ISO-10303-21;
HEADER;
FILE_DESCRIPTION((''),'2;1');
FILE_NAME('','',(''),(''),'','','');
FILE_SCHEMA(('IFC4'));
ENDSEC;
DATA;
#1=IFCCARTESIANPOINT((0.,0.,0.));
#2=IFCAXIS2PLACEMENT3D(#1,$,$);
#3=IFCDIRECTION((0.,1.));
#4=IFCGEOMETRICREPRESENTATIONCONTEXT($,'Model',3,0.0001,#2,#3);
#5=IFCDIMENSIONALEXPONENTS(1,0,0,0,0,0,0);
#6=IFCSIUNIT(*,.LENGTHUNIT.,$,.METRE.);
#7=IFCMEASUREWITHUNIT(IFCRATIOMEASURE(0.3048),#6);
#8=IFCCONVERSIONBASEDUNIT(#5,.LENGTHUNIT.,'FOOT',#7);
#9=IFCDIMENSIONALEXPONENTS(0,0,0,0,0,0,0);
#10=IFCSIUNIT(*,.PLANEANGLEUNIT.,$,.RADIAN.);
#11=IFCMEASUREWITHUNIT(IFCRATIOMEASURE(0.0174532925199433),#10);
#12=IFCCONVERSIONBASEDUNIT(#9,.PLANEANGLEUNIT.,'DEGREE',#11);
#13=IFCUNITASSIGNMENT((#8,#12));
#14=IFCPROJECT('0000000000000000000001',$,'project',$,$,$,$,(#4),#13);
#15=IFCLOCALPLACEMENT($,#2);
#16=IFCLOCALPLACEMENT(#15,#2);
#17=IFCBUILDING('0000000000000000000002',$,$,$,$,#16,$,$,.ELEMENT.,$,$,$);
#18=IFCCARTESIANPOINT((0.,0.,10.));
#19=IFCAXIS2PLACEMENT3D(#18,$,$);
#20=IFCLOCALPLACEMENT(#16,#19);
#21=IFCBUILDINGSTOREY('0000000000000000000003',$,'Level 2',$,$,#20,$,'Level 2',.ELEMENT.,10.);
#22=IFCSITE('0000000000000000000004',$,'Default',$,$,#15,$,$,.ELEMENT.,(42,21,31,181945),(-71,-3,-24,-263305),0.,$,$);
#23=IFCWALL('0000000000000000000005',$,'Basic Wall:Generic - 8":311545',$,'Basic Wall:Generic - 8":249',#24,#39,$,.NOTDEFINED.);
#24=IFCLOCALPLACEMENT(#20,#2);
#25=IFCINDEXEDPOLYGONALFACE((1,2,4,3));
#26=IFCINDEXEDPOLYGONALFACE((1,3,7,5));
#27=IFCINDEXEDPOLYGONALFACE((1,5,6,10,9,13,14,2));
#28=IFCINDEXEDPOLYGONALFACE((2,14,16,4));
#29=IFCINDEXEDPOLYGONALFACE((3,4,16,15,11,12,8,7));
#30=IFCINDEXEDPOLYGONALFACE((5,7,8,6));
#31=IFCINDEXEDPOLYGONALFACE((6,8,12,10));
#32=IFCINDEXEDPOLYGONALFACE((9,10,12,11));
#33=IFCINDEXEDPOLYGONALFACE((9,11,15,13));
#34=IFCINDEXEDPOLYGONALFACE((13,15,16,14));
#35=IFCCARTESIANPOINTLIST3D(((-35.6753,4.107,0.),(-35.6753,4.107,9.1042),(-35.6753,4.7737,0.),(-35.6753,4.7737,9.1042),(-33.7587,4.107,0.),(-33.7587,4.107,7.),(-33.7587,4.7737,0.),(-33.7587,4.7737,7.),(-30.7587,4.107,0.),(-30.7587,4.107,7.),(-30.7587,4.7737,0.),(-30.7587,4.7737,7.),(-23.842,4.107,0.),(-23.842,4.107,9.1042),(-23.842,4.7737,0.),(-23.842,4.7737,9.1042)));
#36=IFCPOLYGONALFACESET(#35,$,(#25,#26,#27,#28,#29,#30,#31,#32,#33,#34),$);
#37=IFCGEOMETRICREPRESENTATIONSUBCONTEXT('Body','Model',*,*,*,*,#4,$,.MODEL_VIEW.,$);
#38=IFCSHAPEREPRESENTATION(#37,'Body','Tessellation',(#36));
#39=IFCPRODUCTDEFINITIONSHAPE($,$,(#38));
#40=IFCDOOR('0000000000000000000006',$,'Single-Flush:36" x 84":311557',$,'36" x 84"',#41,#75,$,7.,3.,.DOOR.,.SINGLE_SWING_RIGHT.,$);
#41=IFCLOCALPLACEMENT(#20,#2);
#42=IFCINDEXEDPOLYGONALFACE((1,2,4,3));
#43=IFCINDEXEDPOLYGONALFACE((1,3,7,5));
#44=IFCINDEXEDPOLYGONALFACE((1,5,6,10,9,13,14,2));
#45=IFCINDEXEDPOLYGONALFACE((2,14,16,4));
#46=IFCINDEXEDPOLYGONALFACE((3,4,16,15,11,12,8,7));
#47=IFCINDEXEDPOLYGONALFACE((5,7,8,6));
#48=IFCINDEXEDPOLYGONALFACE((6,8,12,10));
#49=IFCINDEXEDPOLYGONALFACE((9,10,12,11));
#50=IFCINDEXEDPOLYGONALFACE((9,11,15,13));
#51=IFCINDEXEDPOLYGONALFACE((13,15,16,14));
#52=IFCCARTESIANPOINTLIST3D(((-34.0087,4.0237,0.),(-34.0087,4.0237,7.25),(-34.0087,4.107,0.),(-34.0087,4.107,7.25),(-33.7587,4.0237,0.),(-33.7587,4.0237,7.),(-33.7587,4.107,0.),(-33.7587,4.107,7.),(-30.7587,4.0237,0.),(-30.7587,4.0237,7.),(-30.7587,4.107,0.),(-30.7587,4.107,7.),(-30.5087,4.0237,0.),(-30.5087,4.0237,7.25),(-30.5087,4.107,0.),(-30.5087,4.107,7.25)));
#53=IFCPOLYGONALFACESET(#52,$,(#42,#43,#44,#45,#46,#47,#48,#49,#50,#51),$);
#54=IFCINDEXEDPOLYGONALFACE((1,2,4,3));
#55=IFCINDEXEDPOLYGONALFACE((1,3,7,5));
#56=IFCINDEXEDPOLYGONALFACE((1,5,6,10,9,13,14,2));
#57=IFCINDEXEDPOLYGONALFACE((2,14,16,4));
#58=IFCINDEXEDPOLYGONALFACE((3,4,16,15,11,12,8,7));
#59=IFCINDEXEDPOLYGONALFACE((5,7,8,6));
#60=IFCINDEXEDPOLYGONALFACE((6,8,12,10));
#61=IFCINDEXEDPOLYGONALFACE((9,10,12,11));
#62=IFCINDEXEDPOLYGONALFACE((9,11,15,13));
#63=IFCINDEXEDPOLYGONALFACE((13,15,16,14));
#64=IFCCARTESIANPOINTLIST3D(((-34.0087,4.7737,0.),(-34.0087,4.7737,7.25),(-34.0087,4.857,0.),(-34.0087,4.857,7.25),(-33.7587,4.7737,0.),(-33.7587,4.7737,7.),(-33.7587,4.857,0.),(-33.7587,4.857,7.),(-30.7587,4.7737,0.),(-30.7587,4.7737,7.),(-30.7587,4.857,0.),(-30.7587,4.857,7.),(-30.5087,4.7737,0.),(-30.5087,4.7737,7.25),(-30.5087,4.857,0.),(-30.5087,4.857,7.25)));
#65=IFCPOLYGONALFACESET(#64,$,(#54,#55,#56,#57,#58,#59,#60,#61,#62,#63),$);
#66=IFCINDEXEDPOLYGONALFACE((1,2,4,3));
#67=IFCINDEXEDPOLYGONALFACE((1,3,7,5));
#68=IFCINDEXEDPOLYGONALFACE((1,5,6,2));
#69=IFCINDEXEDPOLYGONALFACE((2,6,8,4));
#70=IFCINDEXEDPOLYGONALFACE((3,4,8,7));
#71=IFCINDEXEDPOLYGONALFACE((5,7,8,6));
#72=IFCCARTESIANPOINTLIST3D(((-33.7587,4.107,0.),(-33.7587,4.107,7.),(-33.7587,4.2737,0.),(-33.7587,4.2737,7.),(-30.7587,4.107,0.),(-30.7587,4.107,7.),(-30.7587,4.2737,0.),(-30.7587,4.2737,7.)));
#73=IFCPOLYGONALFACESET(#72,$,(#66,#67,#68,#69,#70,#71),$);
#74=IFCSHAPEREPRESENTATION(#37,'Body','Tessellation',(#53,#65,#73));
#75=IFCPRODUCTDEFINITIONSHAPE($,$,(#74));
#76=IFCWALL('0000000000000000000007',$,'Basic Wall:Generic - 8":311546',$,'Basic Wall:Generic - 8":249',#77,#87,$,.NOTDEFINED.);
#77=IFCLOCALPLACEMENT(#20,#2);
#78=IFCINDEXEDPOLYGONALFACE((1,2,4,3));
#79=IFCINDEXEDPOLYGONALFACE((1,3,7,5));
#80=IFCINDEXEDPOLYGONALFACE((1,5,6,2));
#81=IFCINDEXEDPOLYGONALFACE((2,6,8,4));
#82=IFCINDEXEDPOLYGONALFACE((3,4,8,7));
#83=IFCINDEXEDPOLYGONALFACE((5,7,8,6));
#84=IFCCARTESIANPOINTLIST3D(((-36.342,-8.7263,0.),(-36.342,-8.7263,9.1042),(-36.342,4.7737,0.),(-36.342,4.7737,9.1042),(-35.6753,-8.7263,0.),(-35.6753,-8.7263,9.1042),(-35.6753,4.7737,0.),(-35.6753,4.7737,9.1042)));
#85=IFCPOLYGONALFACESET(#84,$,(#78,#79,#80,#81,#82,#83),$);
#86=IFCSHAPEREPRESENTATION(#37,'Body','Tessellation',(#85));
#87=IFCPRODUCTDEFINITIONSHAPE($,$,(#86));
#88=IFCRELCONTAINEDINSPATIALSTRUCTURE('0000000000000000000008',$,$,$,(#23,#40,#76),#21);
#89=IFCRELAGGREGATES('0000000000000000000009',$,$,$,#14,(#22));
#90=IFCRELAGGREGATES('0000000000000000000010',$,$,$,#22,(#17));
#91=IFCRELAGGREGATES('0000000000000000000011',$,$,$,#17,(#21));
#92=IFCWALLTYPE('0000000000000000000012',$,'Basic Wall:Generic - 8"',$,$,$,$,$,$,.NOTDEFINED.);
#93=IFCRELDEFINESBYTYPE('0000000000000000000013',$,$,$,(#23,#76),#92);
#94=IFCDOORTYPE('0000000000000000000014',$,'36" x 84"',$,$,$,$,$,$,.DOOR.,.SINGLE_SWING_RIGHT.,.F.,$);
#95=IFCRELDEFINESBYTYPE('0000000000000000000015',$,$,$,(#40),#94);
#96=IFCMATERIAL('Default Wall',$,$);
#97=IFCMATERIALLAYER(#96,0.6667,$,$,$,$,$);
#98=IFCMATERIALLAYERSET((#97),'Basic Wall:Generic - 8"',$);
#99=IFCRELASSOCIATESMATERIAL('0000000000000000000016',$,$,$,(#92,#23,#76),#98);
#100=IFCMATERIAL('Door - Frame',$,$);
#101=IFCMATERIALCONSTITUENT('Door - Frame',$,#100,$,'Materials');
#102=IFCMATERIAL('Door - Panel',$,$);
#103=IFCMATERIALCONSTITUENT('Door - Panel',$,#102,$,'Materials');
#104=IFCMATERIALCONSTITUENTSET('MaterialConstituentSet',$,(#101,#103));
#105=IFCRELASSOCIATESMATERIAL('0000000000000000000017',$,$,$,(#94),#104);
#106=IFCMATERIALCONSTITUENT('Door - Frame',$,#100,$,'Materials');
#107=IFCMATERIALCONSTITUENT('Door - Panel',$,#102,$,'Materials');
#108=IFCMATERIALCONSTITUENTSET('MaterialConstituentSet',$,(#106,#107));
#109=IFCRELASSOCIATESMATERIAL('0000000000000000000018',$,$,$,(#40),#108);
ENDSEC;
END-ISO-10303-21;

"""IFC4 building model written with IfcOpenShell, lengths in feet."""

from ifc_helpers import new_model, entity, si_unit, converted_unit, direction, frame, frame_2d, origin, place, context, subcontext, project, spatial, polyline, rectangle, outline, extrude, clip, bounded_halfspace, source, transform, mapped, material, layer, layer_set, layer_usage, constituent, constituent_set, type_object, type_shapes, element, fill, save


model = new_model("IFC4")

# Units and contexts
model_context = context("Model", 3, precision=0.0001, world=origin(), true_north=direction((0.0, 1.0)))
body_context = subcontext(model_context, "Body", "Model", "MODEL_VIEW")
ifc_project = project(units=[converted_unit("LENGTHUNIT", "FOOT", entity("IfcRatioMeasure", 0.3048), si_unit("LENGTHUNIT", "METRE"), dimensions=[1, 0, 0, 0, 0, 0, 0]), converted_unit("PLANEANGLEUNIT", "DEGREE", entity("IfcRatioMeasure", 0.0174532925199433), si_unit("PLANEANGLEUNIT", "RADIAN"), dimensions=[0, 0, 0, 0, 0, 0, 0])], contexts=[model_context])

# Site, building, storey
site_placement = place(None, origin())
site = spatial("IfcSite", under=ifc_project, at=site_placement, Name="Default", CompositionType="ELEMENT", RefLatitude=(42, 21, 31, 181945), RefLongitude=(-71, -3, -24, -263305), RefElevation=0.0)
building_placement = place(site_placement, origin())
building = spatial("IfcBuilding", under=site, at=building_placement, CompositionType="ELEMENT")
storey_placement = place(building_placement, frame((0.0, 0.0, 10.0)))
storey = spatial("IfcBuildingStorey", under=building, at=storey_placement, Name="Level 2", LongName="Level 2", CompositionType="ELEMENT", Elevation=10.0)

# Shared definitions
ifc_material_1 = material(Name="Default Wall")
ifc_layer = layer(ifc_material_1, 0.6667)
ifc_layer_set = layer_set([ifc_layer], Name="Basic Wall:Generic - 8\"")
wall_type = type_object("IfcWallType", Name="Basic Wall:Generic - 8\"", PredefinedType="NOTDEFINED", material=ifc_layer_set)

# Wall, opening, door
ifc_layer_usage_1 = layer_usage(ifc_layer_set, "AXIS2", "NEGATIVE", 0.3333)
wall_1_placement = place(storey_placement, frame((-35.6753, 4.4404, 0.0)))
wall_1 = element("IfcWall", 1, at=wall_1_placement, inside=storey, type_object=wall_type, material=ifc_layer_usage_1, Name="Basic Wall:Generic - 8\":311545", ObjectType="Basic Wall:Generic - 8\":249", PredefinedType="NOTDEFINED", context=body_context, shape_type="Clipping", body=[
    clip(extrude(rectangle(XDim=11.8333, YDim=0.6667, at=frame_2d((5.9167, 0.0), x_axis=(-1.0, 0.0))), origin(), (0.0, 0.0, 1.0), 9.1042), bounded_halfspace(frame((0.0, -0.3333, 9.1042), z_axis=(0.0, 0.0, -1.0), x_axis=(0.0, -1.0, 0.0)), True, frame((0.0, -0.3333, 9.1042), z_axis=(0.0, 0.0, -1.0), x_axis=(0.0, -1.0, 0.0)), polyline([(0.0, 0.0), (-0.6667, 0.0), (-0.6667, -11.8333), (0.0, -11.8333), (0.0, 0.0)]))),
])
opening_1_placement = place(wall_1_placement, frame((4.9167, 0.3333, 0.0)))
opening_1 = element("IfcOpeningElement", 2, at=opening_1_placement, cuts=wall_1, ObjectType="Opening", PredefinedType="OPENING", context=body_context, shape_type="SweptSolid", body=[
    extrude(rectangle(XDim=3.0, YDim=7.0, at=frame_2d((3.5, 1.5), x_axis=(0.0, 1.0))), frame((0.0, 0.0, 0.0), z_axis=(0.0, -1.0, 0.0), x_axis=(0.0, 0.0, 1.0)), (0.0, 0.0, 1.0), 0.6667),
])
ifc_material_2 = material(Name="Door - Frame")
ifc_constituent_1 = constituent(ifc_material_2, Name="Door - Frame", Category="Materials")
ifc_material_3 = material(Name="Door - Panel")
ifc_constituent_2 = constituent(ifc_material_3, Name="Door - Panel", Category="Materials")
ifc_constituent_set_1 = constituent_set(constituents=[ifc_constituent_1, ifc_constituent_2], Name="MaterialConstituentSet")
ifc_constituent_3 = constituent(ifc_material_2, Name="Door - Frame", Category="Materials")
ifc_constituent_4 = constituent(ifc_material_3, Name="Door - Panel", Category="Materials")
ifc_constituent_set_2 = constituent_set(constituents=[ifc_constituent_3, ifc_constituent_4], Name="MaterialConstituentSet")
door_type = type_object("IfcDoorType", Name="36\" x 84\"", OperationType="SINGLE_SWING_RIGHT", ParameterTakesPrecedence=False, PredefinedType="DOOR", material=ifc_constituent_set_2)
shared_shape_1 = source(origin(), body_context, "Body", "SweptSolid", [
    extrude(outline(polyline([(-1.75, -3.6875), (1.75, -3.6875), (1.75, 3.5625), (1.5, 3.5625), (1.5, -3.4375), (-1.5, -3.4375), (-1.5, 3.5625), (-1.75, 3.5625), (-1.75, -3.6875)])), frame((1.5, 0.6667, 3.5625), z_axis=(0.0, 1.0, 0.0), x_axis=(1.0, 0.0, 0.0)), (0.0, 0.0, 1.0), 0.0833),
    extrude(outline(polyline([(-3.6875, -1.75), (3.5625, -1.75), (3.5625, -1.5), (-3.4375, -1.5), (-3.4375, 1.5), (3.5625, 1.5), (3.5625, 1.75), (-3.6875, 1.75), (-3.6875, -1.75)])), frame((1.5, -0.0833, 3.5625), z_axis=(0.0, 1.0, 0.0), x_axis=(0.0, 0.0, -1.0)), (0.0, 0.0, 1.0), 0.0833),
    extrude(rectangle(XDim=0.1667, YDim=3.0, at=frame_2d((0.0, 0.0), x_axis=(1.0, 0.0))), frame((1.5, 0.5833, 0.0), z_axis=(0.0, 0.0, 1.0), x_axis=(0.0, 1.0, 0.0)), (0.0, 0.0, 1.0), 7.0),
])
type_shapes(door_type, [shared_shape_1])
door_placement = place(opening_1_placement, frame((0.0, 0.0, 0.0), z_axis=(0.0, 0.0, 1.0), x_axis=(-1.0, 0.0, 0.0)))
door = element("IfcDoor", 3, at=door_placement, inside=storey, type_object=door_type, material=ifc_constituent_set_1, Name="Single-Flush:36\" x 84\":311557", ObjectType="36\" x 84\"", OperationType="SINGLE_SWING_RIGHT", OverallHeight=7.0, OverallWidth=3.0, PredefinedType="DOOR", context=body_context, shape_type="MappedRepresentation", body=[
    mapped(shared_shape_1, transform((0.0, 0.0, 0.0), scale=1.0)),
])
fill(opening_1, door)

# Wall
ifc_layer_usage_2 = layer_usage(ifc_layer_set, "AXIS2", "NEGATIVE", 0.3333)
wall_2_placement = place(storey_placement, frame((-36.0087, 4.7737, 0.0), z_axis=(0.0, 0.0, 1.0), x_axis=(0.0, -1.0, 0.0)))
element("IfcWall", 4, at=wall_2_placement, inside=storey, type_object=wall_type, material=ifc_layer_usage_2, Name="Basic Wall:Generic - 8\":311546", ObjectType="Basic Wall:Generic - 8\":249", PredefinedType="NOTDEFINED", context=body_context, shape_type="Clipping", body=[
    clip(extrude(rectangle(XDim=13.5, YDim=0.6667, at=frame_2d((6.75, 0.0), x_axis=(-1.0, 0.0))), origin(), (0.0, 0.0, 1.0), 9.1042), bounded_halfspace(frame((0.0, -0.3333, 9.1042), z_axis=(0.0, 0.0, -1.0), x_axis=(1.0, 0.0, 0.0)), True, frame((0.0, -0.3333, 9.1042), z_axis=(0.0, 0.0, -1.0), x_axis=(1.0, 0.0, 0.0)), polyline([(0.0, 0.0), (0.0, -0.6667), (0.6667, -0.6667), (13.5, -0.6667), (13.5, 0.0), (0.0, 0.0)]))),
])

save(model, "model.ifc")
